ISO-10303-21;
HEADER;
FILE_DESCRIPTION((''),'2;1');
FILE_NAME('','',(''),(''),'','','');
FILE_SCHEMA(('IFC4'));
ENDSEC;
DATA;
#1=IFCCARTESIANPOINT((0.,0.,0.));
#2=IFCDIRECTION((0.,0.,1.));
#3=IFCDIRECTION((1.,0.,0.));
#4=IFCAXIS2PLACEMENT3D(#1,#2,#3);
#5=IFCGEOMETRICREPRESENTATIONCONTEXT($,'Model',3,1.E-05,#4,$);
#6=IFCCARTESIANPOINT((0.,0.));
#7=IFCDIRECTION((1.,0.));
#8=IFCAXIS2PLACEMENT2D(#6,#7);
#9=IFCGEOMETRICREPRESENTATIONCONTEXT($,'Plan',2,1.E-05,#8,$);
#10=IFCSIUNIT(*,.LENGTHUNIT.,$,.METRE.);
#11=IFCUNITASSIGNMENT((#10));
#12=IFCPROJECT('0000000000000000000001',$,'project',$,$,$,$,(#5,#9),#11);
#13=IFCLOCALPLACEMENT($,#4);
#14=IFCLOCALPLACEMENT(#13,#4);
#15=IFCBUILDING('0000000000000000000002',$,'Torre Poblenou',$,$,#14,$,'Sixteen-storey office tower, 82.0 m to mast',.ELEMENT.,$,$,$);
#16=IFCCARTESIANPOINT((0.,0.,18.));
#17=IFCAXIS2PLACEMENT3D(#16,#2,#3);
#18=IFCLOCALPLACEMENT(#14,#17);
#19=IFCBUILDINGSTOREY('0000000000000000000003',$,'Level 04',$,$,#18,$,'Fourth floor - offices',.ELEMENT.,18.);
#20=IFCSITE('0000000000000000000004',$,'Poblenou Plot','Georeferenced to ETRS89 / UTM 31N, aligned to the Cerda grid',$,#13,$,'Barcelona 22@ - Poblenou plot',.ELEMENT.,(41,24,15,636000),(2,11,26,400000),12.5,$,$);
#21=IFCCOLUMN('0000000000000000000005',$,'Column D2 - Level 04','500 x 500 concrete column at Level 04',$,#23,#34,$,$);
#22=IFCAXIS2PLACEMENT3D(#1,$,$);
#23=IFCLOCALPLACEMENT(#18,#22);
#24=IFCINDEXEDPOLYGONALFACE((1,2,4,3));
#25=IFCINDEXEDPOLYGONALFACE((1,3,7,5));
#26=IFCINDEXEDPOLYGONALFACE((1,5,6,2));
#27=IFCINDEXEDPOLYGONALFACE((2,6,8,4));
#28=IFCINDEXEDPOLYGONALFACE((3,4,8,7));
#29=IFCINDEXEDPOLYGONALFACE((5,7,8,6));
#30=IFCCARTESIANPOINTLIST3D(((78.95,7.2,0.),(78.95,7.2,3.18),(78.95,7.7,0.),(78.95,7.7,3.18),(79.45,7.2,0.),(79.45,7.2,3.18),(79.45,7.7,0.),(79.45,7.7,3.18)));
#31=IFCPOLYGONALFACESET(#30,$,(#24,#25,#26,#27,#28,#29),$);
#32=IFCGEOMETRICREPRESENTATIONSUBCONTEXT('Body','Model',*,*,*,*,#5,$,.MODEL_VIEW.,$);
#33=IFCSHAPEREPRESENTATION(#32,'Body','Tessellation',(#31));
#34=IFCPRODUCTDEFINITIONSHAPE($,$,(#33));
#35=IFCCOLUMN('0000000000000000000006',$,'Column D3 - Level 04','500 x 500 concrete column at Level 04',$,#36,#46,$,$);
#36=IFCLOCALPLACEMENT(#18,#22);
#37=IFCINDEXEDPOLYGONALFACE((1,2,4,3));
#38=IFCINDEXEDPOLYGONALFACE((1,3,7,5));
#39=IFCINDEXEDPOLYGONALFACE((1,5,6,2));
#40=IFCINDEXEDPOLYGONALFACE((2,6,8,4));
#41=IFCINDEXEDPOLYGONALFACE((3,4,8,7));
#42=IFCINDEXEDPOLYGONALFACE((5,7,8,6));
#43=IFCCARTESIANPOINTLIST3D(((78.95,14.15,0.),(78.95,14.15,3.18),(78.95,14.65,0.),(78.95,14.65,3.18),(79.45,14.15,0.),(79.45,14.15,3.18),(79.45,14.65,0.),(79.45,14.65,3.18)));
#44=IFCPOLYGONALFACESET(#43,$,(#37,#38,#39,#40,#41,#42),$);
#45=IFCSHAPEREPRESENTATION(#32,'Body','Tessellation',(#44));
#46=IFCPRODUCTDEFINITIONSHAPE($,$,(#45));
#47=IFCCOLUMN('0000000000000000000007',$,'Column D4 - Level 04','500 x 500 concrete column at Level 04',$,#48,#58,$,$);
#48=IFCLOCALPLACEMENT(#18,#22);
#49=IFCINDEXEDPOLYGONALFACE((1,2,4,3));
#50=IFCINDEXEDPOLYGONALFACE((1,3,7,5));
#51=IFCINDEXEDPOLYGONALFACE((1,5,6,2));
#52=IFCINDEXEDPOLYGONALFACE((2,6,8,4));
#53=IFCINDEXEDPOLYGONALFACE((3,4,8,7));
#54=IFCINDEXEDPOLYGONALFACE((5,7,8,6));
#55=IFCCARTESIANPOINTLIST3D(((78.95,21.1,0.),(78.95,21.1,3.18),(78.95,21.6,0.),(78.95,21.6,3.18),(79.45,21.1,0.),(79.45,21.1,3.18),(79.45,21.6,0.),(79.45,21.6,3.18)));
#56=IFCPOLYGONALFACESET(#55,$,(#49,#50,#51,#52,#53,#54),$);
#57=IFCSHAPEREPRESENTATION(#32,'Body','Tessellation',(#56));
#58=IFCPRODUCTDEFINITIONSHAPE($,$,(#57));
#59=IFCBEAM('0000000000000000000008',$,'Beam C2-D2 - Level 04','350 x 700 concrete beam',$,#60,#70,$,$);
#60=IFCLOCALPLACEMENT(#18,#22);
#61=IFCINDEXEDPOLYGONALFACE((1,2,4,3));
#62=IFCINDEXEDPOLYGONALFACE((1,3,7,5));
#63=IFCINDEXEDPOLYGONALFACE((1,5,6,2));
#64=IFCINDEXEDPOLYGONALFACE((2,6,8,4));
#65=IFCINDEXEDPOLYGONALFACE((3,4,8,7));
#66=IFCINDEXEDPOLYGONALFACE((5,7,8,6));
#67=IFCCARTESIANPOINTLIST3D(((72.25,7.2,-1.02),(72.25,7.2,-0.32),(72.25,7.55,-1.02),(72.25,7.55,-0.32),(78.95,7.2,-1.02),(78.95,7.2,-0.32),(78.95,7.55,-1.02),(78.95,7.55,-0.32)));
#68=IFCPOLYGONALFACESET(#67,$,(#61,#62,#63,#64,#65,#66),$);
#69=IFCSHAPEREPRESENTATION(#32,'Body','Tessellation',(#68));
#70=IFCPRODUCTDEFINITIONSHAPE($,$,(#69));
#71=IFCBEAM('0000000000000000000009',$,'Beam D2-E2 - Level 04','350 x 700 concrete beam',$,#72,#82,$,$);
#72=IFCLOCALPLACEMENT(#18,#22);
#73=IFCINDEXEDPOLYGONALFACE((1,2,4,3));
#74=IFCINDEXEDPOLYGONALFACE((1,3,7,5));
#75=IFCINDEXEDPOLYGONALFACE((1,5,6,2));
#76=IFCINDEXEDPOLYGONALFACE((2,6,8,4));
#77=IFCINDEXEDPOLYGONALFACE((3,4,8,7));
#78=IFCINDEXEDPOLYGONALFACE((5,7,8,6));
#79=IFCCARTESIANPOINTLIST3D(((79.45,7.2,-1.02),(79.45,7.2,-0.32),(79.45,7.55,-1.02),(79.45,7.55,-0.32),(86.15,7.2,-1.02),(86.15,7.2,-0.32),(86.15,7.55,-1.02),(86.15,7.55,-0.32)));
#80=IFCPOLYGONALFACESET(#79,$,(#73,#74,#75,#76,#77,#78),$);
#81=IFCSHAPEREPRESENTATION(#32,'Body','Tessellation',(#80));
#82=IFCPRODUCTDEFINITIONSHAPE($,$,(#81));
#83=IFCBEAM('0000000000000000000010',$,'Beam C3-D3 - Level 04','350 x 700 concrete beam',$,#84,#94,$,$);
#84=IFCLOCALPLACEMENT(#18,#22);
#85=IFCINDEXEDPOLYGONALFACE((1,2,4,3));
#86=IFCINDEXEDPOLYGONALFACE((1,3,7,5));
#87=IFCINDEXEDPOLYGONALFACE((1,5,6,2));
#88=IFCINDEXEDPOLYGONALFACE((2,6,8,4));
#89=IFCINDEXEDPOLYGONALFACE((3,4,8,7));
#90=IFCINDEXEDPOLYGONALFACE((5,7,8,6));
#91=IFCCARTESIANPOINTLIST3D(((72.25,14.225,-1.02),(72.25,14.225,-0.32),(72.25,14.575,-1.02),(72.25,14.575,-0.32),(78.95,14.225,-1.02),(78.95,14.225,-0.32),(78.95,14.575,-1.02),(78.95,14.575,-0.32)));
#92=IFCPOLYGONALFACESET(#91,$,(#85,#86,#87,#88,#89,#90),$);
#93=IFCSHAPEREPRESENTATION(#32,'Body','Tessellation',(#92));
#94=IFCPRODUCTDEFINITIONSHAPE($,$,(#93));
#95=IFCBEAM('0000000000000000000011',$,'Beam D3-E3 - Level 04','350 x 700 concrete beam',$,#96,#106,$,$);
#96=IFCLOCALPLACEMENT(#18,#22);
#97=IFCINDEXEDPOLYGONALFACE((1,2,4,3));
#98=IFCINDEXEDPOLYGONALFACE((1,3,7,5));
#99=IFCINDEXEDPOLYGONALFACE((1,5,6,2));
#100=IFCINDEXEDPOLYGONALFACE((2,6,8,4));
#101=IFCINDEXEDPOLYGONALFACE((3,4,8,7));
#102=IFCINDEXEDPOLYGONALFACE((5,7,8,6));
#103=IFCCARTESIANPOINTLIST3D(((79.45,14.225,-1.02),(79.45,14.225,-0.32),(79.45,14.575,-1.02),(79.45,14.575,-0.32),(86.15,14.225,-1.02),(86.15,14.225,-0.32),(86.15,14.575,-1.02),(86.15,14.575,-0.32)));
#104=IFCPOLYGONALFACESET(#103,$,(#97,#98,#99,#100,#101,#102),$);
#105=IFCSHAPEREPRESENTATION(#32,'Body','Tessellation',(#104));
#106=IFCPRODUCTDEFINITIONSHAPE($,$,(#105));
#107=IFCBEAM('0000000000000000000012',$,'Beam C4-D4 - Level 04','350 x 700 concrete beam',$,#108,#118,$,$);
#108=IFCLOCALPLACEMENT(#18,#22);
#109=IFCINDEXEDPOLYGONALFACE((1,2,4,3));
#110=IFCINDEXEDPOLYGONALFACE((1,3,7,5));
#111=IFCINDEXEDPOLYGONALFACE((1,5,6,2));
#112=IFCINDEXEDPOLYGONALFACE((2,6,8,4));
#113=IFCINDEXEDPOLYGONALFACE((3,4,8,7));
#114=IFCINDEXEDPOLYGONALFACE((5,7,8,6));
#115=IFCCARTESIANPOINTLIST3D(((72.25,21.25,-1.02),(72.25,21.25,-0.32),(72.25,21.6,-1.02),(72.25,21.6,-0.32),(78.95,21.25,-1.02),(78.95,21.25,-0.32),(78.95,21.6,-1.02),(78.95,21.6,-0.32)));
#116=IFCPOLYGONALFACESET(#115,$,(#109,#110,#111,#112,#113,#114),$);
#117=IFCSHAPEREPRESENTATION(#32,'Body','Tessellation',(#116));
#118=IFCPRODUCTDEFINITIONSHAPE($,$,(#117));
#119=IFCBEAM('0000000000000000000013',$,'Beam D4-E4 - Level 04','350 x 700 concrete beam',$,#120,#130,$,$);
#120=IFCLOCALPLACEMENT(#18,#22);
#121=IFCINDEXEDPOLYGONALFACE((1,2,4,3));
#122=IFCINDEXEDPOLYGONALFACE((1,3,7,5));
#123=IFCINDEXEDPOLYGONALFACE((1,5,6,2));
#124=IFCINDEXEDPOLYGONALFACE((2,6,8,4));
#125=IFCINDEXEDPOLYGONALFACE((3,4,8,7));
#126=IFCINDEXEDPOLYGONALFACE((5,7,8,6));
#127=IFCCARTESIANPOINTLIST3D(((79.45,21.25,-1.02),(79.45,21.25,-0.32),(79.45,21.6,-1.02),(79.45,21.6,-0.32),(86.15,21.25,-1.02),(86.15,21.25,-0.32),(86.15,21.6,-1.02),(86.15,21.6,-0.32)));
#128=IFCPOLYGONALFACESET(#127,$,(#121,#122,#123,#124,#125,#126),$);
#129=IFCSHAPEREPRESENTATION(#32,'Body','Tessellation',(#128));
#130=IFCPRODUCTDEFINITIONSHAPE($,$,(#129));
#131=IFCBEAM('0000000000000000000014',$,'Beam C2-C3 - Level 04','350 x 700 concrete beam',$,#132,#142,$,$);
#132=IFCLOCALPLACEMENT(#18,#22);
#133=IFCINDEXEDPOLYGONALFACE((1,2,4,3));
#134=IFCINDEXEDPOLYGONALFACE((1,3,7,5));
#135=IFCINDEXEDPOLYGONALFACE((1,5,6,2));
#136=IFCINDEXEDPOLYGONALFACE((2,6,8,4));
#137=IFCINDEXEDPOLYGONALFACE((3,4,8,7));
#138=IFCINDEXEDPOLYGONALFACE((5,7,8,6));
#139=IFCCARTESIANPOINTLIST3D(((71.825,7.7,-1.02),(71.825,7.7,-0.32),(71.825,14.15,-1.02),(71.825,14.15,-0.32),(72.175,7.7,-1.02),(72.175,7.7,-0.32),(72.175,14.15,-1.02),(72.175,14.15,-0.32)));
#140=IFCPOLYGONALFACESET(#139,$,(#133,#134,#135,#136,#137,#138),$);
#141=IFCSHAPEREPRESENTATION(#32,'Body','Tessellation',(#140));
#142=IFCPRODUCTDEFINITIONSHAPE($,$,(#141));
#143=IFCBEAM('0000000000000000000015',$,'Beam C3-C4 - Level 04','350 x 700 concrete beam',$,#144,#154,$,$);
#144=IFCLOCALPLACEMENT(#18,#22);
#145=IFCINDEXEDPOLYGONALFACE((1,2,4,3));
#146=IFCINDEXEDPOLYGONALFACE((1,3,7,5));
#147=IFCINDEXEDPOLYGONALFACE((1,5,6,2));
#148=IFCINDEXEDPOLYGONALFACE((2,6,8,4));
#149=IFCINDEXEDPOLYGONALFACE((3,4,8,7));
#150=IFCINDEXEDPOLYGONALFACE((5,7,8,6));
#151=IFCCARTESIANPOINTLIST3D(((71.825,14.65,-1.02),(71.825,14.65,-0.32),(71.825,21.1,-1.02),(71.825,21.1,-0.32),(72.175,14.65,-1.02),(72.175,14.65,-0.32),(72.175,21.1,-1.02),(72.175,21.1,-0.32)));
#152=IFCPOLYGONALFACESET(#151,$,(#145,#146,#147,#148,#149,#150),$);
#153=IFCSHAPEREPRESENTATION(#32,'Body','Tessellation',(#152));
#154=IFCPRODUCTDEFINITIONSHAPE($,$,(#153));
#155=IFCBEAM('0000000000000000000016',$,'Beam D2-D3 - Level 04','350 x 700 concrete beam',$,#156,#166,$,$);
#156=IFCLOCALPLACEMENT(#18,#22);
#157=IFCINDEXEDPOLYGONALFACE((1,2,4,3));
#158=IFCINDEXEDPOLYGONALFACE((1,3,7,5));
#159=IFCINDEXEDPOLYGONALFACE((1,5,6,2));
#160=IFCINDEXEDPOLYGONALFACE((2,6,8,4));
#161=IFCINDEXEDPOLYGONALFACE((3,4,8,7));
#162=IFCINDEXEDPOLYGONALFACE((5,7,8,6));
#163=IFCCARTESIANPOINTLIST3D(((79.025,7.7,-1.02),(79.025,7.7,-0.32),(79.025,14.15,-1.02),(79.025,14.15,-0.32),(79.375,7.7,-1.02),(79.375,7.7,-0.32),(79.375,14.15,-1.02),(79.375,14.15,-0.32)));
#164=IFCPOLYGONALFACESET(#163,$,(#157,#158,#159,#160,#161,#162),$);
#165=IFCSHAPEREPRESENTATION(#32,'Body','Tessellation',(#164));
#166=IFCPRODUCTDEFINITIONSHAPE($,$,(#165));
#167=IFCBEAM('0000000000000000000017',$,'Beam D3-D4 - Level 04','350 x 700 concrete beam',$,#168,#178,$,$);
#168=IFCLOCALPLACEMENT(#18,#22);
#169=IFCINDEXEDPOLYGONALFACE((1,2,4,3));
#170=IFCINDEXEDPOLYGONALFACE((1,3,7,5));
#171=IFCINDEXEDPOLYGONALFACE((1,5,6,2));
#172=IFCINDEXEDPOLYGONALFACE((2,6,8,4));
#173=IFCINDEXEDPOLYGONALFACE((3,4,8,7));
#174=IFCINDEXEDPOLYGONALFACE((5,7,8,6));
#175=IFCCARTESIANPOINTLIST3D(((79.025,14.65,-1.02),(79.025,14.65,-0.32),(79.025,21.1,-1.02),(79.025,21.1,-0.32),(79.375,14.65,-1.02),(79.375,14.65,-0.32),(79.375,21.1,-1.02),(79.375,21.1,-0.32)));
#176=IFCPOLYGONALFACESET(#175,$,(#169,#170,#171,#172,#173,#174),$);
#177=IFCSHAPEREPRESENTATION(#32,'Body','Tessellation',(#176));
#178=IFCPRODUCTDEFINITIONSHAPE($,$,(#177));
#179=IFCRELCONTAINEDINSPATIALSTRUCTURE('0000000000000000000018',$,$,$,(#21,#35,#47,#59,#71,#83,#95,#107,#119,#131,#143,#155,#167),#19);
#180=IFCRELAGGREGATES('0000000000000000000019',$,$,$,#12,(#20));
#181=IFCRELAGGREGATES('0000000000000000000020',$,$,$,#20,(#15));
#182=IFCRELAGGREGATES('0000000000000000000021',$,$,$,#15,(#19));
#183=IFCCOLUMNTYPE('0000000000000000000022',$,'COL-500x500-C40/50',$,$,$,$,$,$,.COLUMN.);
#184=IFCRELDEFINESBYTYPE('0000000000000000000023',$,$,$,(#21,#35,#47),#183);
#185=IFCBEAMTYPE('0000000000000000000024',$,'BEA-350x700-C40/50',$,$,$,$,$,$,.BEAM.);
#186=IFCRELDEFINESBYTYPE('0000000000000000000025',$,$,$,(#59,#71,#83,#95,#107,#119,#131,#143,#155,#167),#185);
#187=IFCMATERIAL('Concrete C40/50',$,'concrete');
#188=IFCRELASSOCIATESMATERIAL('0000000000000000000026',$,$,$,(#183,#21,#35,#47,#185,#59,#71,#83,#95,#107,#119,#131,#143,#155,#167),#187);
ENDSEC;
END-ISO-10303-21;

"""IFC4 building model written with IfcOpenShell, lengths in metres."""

from ifc_helpers import new_model, si_unit, frame, origin_with_axes, origin_2d_with_axis, place, context, subcontext, project, spatial, line, indexed_curve, rectangle, outline, extrude, material, material_profile, profile_set, profile_usage, type_object, element, save


model = new_model("IFC4")

# Units and contexts
model_context = context("Model", 3, precision=1e-05, world=origin_with_axes())
plan_context = context("Plan", 2, precision=1e-05, world=origin_2d_with_axis())
body_context = subcontext(model_context, "Body", "Model", "MODEL_VIEW")
ifc_project = project(units=[si_unit("LENGTHUNIT", "METRE")], contexts=[model_context, plan_context])

# Site, building, storey
site_placement = place(None, origin_with_axes())
site = spatial("IfcSite", under=ifc_project, at=site_placement, Name="Poblenou Plot", Description="Georeferenced to ETRS89 / UTM 31N, aligned to the Cerda grid", LongName="Barcelona 22@ - Poblenou plot", CompositionType="ELEMENT", RefLatitude=(41, 24, 15, 636000), RefLongitude=(2, 11, 26, 400000), RefElevation=12.5)
building_placement = place(site_placement, origin_with_axes())
building = spatial("IfcBuilding", under=site, at=building_placement, Name="Torre Poblenou", LongName="Sixteen-storey office tower, 82.0 m to mast", CompositionType="ELEMENT")
storey_placement = place(building_placement, frame((0.0, 0.0, 18.0), z_axis=(0.0, 0.0, 1.0), x_axis=(1.0, 0.0, 0.0)))
storey = spatial("IfcBuildingStorey", under=building, at=storey_placement, Name="Level 04", LongName="Fourth floor - offices", CompositionType="ELEMENT", Elevation=18.0)

# Columns
ifc_material_1 = material(Name="Concrete C40/50", Category="concrete")
ifc_material_profile_1 = material_profile(ifc_material_1, rectangle(XDim=0.5, YDim=0.5))
ifc_profile_set_1 = profile_set([ifc_material_profile_1], Name="COL-500x500-C40/50")
ifc_profile_usage_1 = profile_usage(ifc_profile_set_1)
column_type = type_object("IfcColumnType", Name="COL-500x500-C40/50", PredefinedType="COLUMN", material=ifc_profile_set_1)
column_1_placement = place(storey_placement, frame((78.95, 7.2, 0.0), z_axis=(0.0, 0.0, 1.0), x_axis=(1.0, 0.0, 0.0)))
element("IfcColumn", 1, at=column_1_placement, inside=storey, type_object=column_type, material=ifc_profile_usage_1, Name="Column D2 - Level 04", Description="500 x 500 concrete column at Level 04", context=body_context, shape_type="SweptSolid", body=[
    extrude(outline(indexed_curve([(0.0, 0.0), (0.5, 0.0), (0.5, 0.5), (0.0, 0.5)], segments=[line(1, 2, 3, 4, 1)])), origin_with_axes(), (0.0, 0.0, 1.0), 3.18),
])
ifc_profile_usage_2 = profile_usage(ifc_profile_set_1)
column_2_placement = place(storey_placement, frame((78.95, 14.15, 0.0), z_axis=(0.0, 0.0, 1.0), x_axis=(1.0, 0.0, 0.0)))
element("IfcColumn", 2, at=column_2_placement, inside=storey, type_object=column_type, material=ifc_profile_usage_2, Name="Column D3 - Level 04", Description="500 x 500 concrete column at Level 04", context=body_context, shape_type="SweptSolid", body=[
    extrude(outline(indexed_curve([(0.0, 0.0), (0.5, 0.0), (0.5, 0.5), (0.0, 0.5)], segments=[line(1, 2, 3, 4, 1)])), origin_with_axes(), (0.0, 0.0, 1.0), 3.18),
])
ifc_profile_usage_3 = profile_usage(ifc_profile_set_1)
column_3_placement = place(storey_placement, frame((78.95, 21.1, 0.0), z_axis=(0.0, 0.0, 1.0), x_axis=(1.0, 0.0, 0.0)))
element("IfcColumn", 3, at=column_3_placement, inside=storey, type_object=column_type, material=ifc_profile_usage_3, Name="Column D4 - Level 04", Description="500 x 500 concrete column at Level 04", context=body_context, shape_type="SweptSolid", body=[
    extrude(outline(indexed_curve([(0.0, 0.0), (0.5, 0.0), (0.5, 0.5), (0.0, 0.5)], segments=[line(1, 2, 3, 4, 1)])), origin_with_axes(), (0.0, 0.0, 1.0), 3.18),
])

# Beams
ifc_material_profile_2 = material_profile(ifc_material_1, rectangle(XDim=0.35, YDim=0.7))
ifc_profile_set_2 = profile_set([ifc_material_profile_2], Name="BEA-350x700-C40/50")
ifc_profile_usage_4 = profile_usage(ifc_profile_set_2)
beam_type = type_object("IfcBeamType", Name="BEA-350x700-C40/50", PredefinedType="BEAM", material=ifc_profile_set_2)
beam_1_placement = place(storey_placement, frame((72.25, 7.2, -1.02), z_axis=(0.0, 0.0, 1.0), x_axis=(1.0, 0.0, 0.0)))
element("IfcBeam", 4, at=beam_1_placement, inside=storey, type_object=beam_type, material=ifc_profile_usage_4, Name="Beam C2-D2 - Level 04", Description="350 x 700 concrete beam", context=body_context, shape_type="SweptSolid", body=[
    extrude(outline(indexed_curve([(0.0, 0.0), (6.7, 0.0), (6.7, 0.35), (0.0, 0.35)], segments=[line(1, 2, 3, 4, 1)])), origin_with_axes(), (0.0, 0.0, 1.0), 0.7),
])
ifc_profile_usage_5 = profile_usage(ifc_profile_set_2)
beam_2_placement = place(storey_placement, frame((79.45, 7.2, -1.02), z_axis=(0.0, 0.0, 1.0), x_axis=(1.0, 0.0, 0.0)))
element("IfcBeam", 5, at=beam_2_placement, inside=storey, type_object=beam_type, material=ifc_profile_usage_5, Name="Beam D2-E2 - Level 04", Description="350 x 700 concrete beam", context=body_context, shape_type="SweptSolid", body=[
    extrude(outline(indexed_curve([(0.0, 0.0), (6.7, 0.0), (6.7, 0.35), (0.0, 0.35)], segments=[line(1, 2, 3, 4, 1)])), origin_with_axes(), (0.0, 0.0, 1.0), 0.7),
])
ifc_profile_usage_6 = profile_usage(ifc_profile_set_2)
beam_3_placement = place(storey_placement, frame((72.25, 14.225, -1.02), z_axis=(0.0, 0.0, 1.0), x_axis=(1.0, 0.0, 0.0)))
element("IfcBeam", 6, at=beam_3_placement, inside=storey, type_object=beam_type, material=ifc_profile_usage_6, Name="Beam C3-D3 - Level 04", Description="350 x 700 concrete beam", context=body_context, shape_type="SweptSolid", body=[
    extrude(outline(indexed_curve([(0.0, 0.0), (6.7, 0.0), (6.7, 0.35), (0.0, 0.35)], segments=[line(1, 2, 3, 4, 1)])), origin_with_axes(), (0.0, 0.0, 1.0), 0.7),
])
ifc_profile_usage_7 = profile_usage(ifc_profile_set_2)
beam_4_placement = place(storey_placement, frame((79.45, 14.225, -1.02), z_axis=(0.0, 0.0, 1.0), x_axis=(1.0, 0.0, 0.0)))
element("IfcBeam", 7, at=beam_4_placement, inside=storey, type_object=beam_type, material=ifc_profile_usage_7, Name="Beam D3-E3 - Level 04", Description="350 x 700 concrete beam", context=body_context, shape_type="SweptSolid", body=[
    extrude(outline(indexed_curve([(0.0, 0.0), (6.7, 0.0), (6.7, 0.35), (0.0, 0.35)], segments=[line(1, 2, 3, 4, 1)])), origin_with_axes(), (0.0, 0.0, 1.0), 0.7),
])
ifc_profile_usage_8 = profile_usage(ifc_profile_set_2)
beam_5_placement = place(storey_placement, frame((72.25, 21.25, -1.02), z_axis=(0.0, 0.0, 1.0), x_axis=(1.0, 0.0, 0.0)))
element("IfcBeam", 8, at=beam_5_placement, inside=storey, type_object=beam_type, material=ifc_profile_usage_8, Name="Beam C4-D4 - Level 04", Description="350 x 700 concrete beam", context=body_context, shape_type="SweptSolid", body=[
    extrude(outline(indexed_curve([(0.0, 0.0), (6.7, 0.0), (6.7, 0.35), (0.0, 0.35)], segments=[line(1, 2, 3, 4, 1)])), origin_with_axes(), (0.0, 0.0, 1.0), 0.7),
])
ifc_profile_usage_9 = profile_usage(ifc_profile_set_2)
beam_6_placement = place(storey_placement, frame((79.45, 21.25, -1.02), z_axis=(0.0, 0.0, 1.0), x_axis=(1.0, 0.0, 0.0)))
element("IfcBeam", 9, at=beam_6_placement, inside=storey, type_object=beam_type, material=ifc_profile_usage_9, Name="Beam D4-E4 - Level 04", Description="350 x 700 concrete beam", context=body_context, shape_type="SweptSolid", body=[
    extrude(outline(indexed_curve([(0.0, 0.0), (6.7, 0.0), (6.7, 0.35), (0.0, 0.35)], segments=[line(1, 2, 3, 4, 1)])), origin_with_axes(), (0.0, 0.0, 1.0), 0.7),
])
ifc_profile_usage_10 = profile_usage(ifc_profile_set_2)
beam_7_placement = place(storey_placement, frame((72.175, 7.7, -1.02), z_axis=(0.0, 0.0, 1.0), x_axis=(0.0, 1.0, 0.0)))
element("IfcBeam", 10, at=beam_7_placement, inside=storey, type_object=beam_type, material=ifc_profile_usage_10, Name="Beam C2-C3 - Level 04", Description="350 x 700 concrete beam", context=body_context, shape_type="SweptSolid", body=[
    extrude(outline(indexed_curve([(0.0, 0.0), (6.45, 0.0), (6.45, 0.35), (0.0, 0.35)], segments=[line(1, 2, 3, 4, 1)])), origin_with_axes(), (0.0, 0.0, 1.0), 0.7),
])
ifc_profile_usage_11 = profile_usage(ifc_profile_set_2)
beam_8_placement = place(storey_placement, frame((72.175, 14.65, -1.02), z_axis=(0.0, 0.0, 1.0), x_axis=(0.0, 1.0, 0.0)))
element("IfcBeam", 11, at=beam_8_placement, inside=storey, type_object=beam_type, material=ifc_profile_usage_11, Name="Beam C3-C4 - Level 04", Description="350 x 700 concrete beam", context=body_context, shape_type="SweptSolid", body=[
    extrude(outline(indexed_curve([(0.0, 0.0), (6.45, 0.0), (6.45, 0.35), (0.0, 0.35)], segments=[line(1, 2, 3, 4, 1)])), origin_with_axes(), (0.0, 0.0, 1.0), 0.7),
])
ifc_profile_usage_12 = profile_usage(ifc_profile_set_2)
beam_9_placement = place(storey_placement, frame((79.375, 7.7, -1.02), z_axis=(0.0, 0.0, 1.0), x_axis=(0.0, 1.0, 0.0)))
element("IfcBeam", 12, at=beam_9_placement, inside=storey, type_object=beam_type, material=ifc_profile_usage_12, Name="Beam D2-D3 - Level 04", Description="350 x 700 concrete beam", context=body_context, shape_type="SweptSolid", body=[
    extrude(outline(indexed_curve([(0.0, 0.0), (6.45, 0.0), (6.45, 0.35), (0.0, 0.35)], segments=[line(1, 2, 3, 4, 1)])), origin_with_axes(), (0.0, 0.0, 1.0), 0.7),
])
ifc_profile_usage_13 = profile_usage(ifc_profile_set_2)
beam_10_placement = place(storey_placement, frame((79.375, 14.65, -1.02), z_axis=(0.0, 0.0, 1.0), x_axis=(0.0, 1.0, 0.0)))
element("IfcBeam", 13, at=beam_10_placement, inside=storey, type_object=beam_type, material=ifc_profile_usage_13, Name="Beam D3-D4 - Level 04", Description="350 x 700 concrete beam", context=body_context, shape_type="SweptSolid", body=[
    extrude(outline(indexed_curve([(0.0, 0.0), (6.45, 0.0), (6.45, 0.35), (0.0, 0.35)], segments=[line(1, 2, 3, 4, 1)])), origin_with_axes(), (0.0, 0.0, 1.0), 0.7),
])

save(model, "model.ifc")
